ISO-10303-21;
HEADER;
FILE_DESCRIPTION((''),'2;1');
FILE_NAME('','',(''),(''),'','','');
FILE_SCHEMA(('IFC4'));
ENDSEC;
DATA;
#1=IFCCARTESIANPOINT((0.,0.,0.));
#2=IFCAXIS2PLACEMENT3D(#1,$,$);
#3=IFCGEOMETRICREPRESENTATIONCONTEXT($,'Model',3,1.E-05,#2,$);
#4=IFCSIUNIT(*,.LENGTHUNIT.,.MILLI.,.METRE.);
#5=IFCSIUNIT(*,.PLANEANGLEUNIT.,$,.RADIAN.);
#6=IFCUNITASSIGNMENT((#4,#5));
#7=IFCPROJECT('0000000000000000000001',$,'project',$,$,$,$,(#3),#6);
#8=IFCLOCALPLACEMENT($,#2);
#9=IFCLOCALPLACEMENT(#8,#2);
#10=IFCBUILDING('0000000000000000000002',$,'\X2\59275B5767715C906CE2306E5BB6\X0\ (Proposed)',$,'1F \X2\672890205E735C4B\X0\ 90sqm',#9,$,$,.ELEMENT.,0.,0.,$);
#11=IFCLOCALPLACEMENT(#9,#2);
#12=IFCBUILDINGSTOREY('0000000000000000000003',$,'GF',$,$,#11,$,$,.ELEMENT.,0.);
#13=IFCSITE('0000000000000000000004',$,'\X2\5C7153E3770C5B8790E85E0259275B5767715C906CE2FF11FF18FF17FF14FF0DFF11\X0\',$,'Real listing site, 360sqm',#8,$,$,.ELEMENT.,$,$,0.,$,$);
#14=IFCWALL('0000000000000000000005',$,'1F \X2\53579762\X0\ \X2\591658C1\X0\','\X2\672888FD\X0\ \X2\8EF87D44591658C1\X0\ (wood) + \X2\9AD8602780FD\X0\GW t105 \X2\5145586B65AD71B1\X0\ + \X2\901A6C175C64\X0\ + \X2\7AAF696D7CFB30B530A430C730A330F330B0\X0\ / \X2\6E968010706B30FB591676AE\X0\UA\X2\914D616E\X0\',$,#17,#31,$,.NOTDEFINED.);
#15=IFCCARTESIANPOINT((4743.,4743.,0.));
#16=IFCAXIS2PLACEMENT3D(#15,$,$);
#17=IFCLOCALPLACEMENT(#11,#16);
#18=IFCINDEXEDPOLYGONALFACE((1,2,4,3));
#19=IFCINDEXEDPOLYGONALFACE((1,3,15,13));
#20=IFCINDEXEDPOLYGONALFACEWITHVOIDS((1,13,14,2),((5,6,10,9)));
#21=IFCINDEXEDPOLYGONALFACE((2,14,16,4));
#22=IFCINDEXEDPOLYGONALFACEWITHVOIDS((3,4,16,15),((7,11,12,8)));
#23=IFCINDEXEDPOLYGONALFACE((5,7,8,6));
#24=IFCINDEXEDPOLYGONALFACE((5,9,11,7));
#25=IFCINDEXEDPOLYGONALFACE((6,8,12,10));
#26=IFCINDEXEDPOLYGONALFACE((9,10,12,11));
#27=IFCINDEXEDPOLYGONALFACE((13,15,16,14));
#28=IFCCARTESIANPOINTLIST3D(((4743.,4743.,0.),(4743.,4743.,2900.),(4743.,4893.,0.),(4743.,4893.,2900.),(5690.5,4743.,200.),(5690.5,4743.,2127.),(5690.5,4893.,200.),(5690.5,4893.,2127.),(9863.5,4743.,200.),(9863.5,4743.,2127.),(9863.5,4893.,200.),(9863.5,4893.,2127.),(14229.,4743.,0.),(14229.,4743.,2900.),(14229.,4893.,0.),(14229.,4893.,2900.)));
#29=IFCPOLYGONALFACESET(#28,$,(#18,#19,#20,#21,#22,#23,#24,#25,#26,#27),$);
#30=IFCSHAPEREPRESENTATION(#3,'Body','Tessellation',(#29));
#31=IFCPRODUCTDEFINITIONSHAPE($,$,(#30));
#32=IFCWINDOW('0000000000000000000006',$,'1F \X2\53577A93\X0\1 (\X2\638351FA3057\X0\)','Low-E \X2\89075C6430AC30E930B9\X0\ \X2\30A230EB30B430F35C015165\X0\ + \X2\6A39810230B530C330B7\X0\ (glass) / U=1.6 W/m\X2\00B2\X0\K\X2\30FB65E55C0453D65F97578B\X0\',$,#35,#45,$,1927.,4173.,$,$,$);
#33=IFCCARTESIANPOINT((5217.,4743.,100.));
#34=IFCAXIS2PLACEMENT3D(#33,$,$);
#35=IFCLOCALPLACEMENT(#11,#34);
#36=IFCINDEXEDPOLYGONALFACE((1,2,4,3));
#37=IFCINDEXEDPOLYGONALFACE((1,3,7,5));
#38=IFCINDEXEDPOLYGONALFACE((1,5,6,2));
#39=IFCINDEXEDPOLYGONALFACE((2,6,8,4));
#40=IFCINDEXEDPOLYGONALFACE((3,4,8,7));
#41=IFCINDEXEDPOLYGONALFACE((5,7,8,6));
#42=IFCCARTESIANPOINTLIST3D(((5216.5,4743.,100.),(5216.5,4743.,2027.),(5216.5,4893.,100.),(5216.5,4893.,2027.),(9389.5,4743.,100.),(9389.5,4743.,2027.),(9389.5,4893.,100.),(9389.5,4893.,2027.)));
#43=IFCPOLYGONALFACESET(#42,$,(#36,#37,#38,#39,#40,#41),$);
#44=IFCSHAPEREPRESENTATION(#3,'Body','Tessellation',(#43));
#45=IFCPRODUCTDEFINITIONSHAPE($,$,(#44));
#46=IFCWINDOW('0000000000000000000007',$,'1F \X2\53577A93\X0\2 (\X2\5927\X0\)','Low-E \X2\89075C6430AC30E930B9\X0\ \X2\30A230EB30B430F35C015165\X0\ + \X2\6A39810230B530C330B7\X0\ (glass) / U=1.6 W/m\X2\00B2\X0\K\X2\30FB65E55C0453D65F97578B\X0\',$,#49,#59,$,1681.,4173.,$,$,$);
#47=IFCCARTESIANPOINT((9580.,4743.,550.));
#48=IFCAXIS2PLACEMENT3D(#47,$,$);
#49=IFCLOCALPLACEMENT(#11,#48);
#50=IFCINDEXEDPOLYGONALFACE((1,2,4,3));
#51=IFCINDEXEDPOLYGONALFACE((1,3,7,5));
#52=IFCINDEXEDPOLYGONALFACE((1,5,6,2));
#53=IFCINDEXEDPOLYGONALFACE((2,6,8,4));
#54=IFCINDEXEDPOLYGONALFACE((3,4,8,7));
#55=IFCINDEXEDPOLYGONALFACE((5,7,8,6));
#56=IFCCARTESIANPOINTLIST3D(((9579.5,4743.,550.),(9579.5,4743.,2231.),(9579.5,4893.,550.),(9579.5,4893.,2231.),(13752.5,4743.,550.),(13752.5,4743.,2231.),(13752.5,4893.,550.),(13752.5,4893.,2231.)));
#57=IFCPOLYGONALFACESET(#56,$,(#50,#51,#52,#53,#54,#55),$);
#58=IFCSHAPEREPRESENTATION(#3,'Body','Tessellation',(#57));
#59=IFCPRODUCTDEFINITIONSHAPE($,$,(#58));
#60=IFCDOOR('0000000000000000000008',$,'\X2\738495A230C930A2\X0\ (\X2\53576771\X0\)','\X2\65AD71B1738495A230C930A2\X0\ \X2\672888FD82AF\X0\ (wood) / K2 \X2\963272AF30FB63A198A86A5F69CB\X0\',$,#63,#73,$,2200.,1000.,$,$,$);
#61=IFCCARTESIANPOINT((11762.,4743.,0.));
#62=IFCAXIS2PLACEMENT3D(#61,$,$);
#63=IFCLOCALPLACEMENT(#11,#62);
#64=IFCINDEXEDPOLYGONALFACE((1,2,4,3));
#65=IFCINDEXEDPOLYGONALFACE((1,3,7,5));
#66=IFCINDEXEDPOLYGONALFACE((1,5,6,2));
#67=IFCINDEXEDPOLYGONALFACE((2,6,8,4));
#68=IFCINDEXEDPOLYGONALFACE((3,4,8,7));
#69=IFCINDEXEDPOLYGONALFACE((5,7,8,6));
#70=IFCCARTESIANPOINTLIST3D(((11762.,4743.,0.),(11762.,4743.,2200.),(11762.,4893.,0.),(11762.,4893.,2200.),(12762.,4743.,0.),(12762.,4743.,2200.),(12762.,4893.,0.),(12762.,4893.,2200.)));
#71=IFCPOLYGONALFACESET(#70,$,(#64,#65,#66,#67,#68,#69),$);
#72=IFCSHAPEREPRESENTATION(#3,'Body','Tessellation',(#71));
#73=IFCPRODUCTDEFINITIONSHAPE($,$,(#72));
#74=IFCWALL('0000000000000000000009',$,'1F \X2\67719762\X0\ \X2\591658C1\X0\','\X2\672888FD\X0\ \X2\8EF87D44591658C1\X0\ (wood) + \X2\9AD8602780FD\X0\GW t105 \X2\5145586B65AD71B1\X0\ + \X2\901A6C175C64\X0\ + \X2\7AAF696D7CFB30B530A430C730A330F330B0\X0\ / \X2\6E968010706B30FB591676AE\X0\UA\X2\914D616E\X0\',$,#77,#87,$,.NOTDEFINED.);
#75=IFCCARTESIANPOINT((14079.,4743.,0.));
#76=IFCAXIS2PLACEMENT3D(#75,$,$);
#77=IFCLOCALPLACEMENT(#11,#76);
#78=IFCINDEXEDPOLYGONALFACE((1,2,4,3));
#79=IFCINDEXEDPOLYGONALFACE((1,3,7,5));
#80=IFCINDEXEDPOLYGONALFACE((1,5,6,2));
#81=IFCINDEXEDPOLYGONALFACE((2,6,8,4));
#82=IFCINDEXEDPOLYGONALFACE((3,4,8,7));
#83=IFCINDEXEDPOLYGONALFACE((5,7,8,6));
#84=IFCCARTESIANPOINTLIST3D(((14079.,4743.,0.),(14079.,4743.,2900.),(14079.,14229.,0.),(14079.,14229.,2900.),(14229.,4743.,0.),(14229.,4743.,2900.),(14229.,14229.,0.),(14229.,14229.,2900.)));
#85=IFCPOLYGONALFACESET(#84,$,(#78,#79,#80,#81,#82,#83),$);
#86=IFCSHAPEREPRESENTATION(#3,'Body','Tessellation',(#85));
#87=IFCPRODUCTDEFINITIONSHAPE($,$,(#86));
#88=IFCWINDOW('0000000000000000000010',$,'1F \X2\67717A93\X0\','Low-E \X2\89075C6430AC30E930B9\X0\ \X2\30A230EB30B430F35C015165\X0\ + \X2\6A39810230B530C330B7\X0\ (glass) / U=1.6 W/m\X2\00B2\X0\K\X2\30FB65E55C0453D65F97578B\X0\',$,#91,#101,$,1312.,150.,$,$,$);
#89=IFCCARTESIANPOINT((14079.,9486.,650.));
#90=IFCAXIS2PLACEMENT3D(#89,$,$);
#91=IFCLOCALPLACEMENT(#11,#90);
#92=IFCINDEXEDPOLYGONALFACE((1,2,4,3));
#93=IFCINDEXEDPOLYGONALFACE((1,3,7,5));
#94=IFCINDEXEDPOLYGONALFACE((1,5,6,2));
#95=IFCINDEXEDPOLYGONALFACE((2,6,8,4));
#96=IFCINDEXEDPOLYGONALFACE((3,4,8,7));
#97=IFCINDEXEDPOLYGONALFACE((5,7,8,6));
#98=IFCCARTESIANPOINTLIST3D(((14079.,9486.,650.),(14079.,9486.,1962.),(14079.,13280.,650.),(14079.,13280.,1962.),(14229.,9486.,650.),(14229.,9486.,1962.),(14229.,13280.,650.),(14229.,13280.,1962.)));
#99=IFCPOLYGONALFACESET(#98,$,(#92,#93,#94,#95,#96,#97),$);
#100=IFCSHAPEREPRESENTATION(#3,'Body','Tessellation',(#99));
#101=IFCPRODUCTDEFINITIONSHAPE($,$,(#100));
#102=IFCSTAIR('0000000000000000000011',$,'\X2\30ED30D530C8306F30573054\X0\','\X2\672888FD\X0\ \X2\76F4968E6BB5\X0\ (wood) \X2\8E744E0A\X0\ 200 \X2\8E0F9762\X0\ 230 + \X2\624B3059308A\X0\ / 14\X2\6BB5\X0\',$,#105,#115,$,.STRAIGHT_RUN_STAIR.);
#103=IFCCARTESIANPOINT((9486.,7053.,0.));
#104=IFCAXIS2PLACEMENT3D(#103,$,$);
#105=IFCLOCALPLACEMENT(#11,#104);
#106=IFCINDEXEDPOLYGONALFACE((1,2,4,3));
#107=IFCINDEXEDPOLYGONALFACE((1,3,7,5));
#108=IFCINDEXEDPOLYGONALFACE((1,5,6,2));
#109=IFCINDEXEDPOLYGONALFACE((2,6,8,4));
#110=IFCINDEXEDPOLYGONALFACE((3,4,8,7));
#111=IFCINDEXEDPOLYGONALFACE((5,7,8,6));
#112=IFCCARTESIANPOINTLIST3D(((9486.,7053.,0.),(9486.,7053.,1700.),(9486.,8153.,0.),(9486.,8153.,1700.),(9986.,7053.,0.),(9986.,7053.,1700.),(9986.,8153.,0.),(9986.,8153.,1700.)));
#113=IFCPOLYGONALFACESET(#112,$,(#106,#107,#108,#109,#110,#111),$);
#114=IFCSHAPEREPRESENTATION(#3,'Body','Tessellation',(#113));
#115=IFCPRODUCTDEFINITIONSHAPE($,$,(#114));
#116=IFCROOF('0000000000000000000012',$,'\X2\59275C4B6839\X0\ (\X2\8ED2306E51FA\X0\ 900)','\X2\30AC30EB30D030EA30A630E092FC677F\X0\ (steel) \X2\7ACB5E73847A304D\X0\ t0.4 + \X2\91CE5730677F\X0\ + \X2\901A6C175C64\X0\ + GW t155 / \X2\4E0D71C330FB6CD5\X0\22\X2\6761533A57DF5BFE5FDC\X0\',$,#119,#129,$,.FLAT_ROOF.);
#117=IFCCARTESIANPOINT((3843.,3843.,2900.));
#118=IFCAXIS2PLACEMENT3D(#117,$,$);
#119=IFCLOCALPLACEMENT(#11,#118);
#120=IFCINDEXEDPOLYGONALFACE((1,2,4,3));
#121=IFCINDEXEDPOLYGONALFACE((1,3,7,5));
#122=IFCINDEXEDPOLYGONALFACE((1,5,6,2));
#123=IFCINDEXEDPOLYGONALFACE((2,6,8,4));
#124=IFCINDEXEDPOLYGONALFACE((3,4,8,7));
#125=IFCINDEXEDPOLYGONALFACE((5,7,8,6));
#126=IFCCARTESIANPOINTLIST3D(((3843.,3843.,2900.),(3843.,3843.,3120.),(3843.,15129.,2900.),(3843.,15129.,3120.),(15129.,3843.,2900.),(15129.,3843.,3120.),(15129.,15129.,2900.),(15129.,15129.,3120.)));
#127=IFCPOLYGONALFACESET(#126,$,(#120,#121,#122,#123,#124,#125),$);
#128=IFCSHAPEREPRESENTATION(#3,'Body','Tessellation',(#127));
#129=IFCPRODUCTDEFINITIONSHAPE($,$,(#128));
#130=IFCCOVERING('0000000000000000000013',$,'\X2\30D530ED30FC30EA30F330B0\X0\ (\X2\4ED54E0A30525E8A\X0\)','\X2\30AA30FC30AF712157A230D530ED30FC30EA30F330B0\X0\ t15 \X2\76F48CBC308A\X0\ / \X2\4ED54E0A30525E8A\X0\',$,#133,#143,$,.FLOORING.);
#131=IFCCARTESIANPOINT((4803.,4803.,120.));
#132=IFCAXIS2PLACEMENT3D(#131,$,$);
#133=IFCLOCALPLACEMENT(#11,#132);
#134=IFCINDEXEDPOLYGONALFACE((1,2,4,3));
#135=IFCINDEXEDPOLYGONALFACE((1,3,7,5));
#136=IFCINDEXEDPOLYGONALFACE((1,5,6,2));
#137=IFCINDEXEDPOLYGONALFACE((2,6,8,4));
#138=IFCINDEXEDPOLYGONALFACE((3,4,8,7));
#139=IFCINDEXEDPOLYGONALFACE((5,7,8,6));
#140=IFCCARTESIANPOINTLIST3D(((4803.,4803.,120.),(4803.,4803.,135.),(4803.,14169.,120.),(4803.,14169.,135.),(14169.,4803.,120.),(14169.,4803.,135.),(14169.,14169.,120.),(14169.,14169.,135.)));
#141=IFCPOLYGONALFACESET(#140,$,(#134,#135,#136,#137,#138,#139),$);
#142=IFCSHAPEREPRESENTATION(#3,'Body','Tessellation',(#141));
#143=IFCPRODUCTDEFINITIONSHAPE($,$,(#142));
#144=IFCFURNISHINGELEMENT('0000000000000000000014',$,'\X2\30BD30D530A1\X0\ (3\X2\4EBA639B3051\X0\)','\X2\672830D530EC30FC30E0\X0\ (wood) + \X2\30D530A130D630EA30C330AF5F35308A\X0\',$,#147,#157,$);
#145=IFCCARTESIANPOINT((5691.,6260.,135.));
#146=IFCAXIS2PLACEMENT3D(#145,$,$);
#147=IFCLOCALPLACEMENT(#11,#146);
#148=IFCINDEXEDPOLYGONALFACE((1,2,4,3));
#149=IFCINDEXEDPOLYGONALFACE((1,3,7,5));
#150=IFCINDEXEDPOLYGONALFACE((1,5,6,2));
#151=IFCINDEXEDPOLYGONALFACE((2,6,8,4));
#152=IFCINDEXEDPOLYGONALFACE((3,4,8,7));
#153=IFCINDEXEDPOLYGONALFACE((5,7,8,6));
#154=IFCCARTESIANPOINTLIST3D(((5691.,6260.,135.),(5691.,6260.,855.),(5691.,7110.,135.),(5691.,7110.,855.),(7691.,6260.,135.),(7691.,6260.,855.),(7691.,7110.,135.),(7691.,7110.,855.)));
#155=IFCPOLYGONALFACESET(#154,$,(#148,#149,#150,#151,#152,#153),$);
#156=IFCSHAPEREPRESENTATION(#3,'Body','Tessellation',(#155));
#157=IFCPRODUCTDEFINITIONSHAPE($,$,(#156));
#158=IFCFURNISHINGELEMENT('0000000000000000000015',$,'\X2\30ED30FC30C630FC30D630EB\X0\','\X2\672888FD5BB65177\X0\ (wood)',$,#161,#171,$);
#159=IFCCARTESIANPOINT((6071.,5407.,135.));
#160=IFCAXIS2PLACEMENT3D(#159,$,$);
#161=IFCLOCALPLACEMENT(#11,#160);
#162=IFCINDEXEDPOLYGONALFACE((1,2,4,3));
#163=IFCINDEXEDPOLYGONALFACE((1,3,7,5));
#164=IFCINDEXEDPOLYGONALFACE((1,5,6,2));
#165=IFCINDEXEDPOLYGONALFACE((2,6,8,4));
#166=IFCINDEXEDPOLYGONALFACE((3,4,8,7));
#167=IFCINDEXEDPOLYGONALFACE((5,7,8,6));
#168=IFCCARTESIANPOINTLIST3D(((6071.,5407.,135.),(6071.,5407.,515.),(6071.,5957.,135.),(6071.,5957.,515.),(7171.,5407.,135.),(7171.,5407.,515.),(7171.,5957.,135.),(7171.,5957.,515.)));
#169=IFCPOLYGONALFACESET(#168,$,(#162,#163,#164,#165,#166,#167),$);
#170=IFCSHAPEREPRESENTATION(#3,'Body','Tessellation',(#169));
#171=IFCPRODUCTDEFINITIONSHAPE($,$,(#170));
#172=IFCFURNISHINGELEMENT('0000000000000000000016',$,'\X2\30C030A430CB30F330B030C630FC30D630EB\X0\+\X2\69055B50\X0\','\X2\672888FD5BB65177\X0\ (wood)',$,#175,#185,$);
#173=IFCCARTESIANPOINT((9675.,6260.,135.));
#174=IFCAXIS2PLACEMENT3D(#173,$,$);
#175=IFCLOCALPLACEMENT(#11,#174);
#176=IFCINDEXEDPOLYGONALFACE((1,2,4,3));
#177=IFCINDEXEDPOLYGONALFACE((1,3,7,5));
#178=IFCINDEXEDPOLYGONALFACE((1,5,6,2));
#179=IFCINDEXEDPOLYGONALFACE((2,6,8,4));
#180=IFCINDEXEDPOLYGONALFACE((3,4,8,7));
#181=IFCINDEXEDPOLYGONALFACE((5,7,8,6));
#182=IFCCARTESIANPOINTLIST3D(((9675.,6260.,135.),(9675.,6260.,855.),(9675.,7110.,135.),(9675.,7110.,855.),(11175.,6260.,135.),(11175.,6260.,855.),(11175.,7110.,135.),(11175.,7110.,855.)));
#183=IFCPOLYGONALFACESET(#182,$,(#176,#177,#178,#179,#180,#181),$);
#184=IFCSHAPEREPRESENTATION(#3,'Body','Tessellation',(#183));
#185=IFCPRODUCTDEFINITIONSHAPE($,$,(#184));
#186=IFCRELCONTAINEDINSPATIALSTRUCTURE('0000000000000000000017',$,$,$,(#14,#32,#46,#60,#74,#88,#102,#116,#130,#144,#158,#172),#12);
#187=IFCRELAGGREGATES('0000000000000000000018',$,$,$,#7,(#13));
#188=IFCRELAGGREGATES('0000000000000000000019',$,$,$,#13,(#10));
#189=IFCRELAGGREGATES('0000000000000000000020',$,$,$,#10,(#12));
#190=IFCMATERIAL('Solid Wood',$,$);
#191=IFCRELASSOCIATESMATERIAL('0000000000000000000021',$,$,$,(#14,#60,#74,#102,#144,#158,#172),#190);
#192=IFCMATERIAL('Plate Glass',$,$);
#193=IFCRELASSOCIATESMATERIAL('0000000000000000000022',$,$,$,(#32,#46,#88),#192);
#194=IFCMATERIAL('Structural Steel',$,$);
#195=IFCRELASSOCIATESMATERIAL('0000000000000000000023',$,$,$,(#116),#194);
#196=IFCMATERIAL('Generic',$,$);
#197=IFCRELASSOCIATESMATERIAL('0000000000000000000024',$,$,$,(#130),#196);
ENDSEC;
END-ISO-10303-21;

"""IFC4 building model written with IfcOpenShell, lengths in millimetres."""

from ifc_helpers import new_model, si_unit, frame, frame_2d, origin, place, context, project, spatial, rectangle, extrude, material, element, fill, save


model = new_model("IFC4")

# Units and contexts
model_context = context("Model", 3, precision=1e-05, world=origin())
ifc_project = project(units=[si_unit("LENGTHUNIT", "METRE", prefix="MILLI"), si_unit("PLANEANGLEUNIT", "RADIAN")], contexts=[model_context])

# Site, building, storey
site_placement = place(None, origin())
site = spatial("IfcSite", under=ifc_project, at=site_placement, Name="山口県宇部市大字東岐波１８７４－１", ObjectType="Real listing site, 360sqm", CompositionType="ELEMENT", RefElevation=0.0)
building_placement = place(site_placement, origin())
building = spatial("IfcBuilding", under=site, at=building_placement, Name="大字東岐波の家 (Proposed)", ObjectType="1F 木造平屋 90sqm", CompositionType="ELEMENT", ElevationOfRefHeight=0.0, ElevationOfTerrain=0.0)
storey_placement = place(building_placement, origin())
storey = spatial("IfcBuildingStorey", under=building, at=storey_placement, Name="GF", CompositionType="ELEMENT", Elevation=0.0)

# Shared definitions
ifc_material_1 = material(Name="Solid Wood")

# Wall, openings, windows, door
wall_1_placement = place(storey_placement, frame((4743.0, 4743.0, 0.0)))
wall_1 = element("IfcWall", 1, at=wall_1_placement, inside=storey, material=ifc_material_1, Name="1F 南面 外壁", Description="木製 軸組外壁 (wood) + 高性能GW t105 充填断熱 + 通気層 + 窯業系サイディング / 準耐火・外皮UA配慮", PredefinedType="NOTDEFINED", context=model_context, shape_type="SweptSolid", body=[
    extrude(rectangle(XDim=9486.0, YDim=150.0, at=frame_2d((4743.0, 75.0))), frame((4743.0, 4743.0, 0.0)), (0.0, 0.0, 1.0), 2900.0),
])
opening_1_placement = place(storey_placement, frame((5217.0, 4743.0, 100.0)))
opening_1 = element("IfcOpeningElement", 2, at=opening_1_placement, cuts=wall_1, PredefinedType="NOTDEFINED", context=model_context, shape_type="SweptSolid", body=[
    extrude(rectangle(XDim=4173.0, YDim=150.0, at=frame_2d((2086.0, 75.0))), frame((5217.0, 4743.0, 100.0)), (0.0, 0.0, 1.0), 1927.0),
])
opening_2_placement = place(storey_placement, frame((9580.0, 4743.0, 550.0)))
opening_2 = element("IfcOpeningElement", 3, at=opening_2_placement, cuts=wall_1, PredefinedType="NOTDEFINED", context=model_context, shape_type="SweptSolid", body=[
    extrude(rectangle(XDim=4173.0, YDim=150.0, at=frame_2d((2086.0, 75.0))), frame((9580.0, 4743.0, 550.0)), (0.0, 0.0, 1.0), 1681.0),
])
opening_3_placement = place(storey_placement, frame((11762.0, 4743.0, 0.0)))
opening_3 = element("IfcOpeningElement", 4, at=opening_3_placement, cuts=wall_1, PredefinedType="NOTDEFINED", context=model_context, shape_type="SweptSolid", body=[
    extrude(rectangle(XDim=1000.0, YDim=150.0, at=frame_2d((500.0, 75.0))), frame((11762.0, 4743.0, 0.0)), (0.0, 0.0, 1.0), 2200.0),
])
ifc_material_2 = material(Name="Plate Glass")
window_1_placement = place(storey_placement, frame((5217.0, 4743.0, 100.0)))
window_1 = element("IfcWindow", 5, at=window_1_placement, inside=storey, material=ifc_material_2, Name="1F 南窓1 (掃出し)", Description="Low-E 複層ガラス アルゴン封入 + 樹脂サッシ (glass) / U=1.6 W/m²K・日射取得型", OverallHeight=1927.0, OverallWidth=4173.0, context=model_context, shape_type="SweptSolid", body=[
    extrude(rectangle(XDim=4173.0, YDim=150.0, at=frame_2d((2086.0, 75.0))), frame((5217.0, 4743.0, 100.0)), (0.0, 0.0, 1.0), 1927.0),
])
fill(opening_1, window_1)
window_2_placement = place(storey_placement, frame((9580.0, 4743.0, 550.0)))
window_2 = element("IfcWindow", 6, at=window_2_placement, inside=storey, material=ifc_material_2, Name="1F 南窓2 (大)", Description="Low-E 複層ガラス アルゴン封入 + 樹脂サッシ (glass) / U=1.6 W/m²K・日射取得型", OverallHeight=1681.0, OverallWidth=4173.0, context=model_context, shape_type="SweptSolid", body=[
    extrude(rectangle(XDim=4173.0, YDim=150.0, at=frame_2d((2086.0, 75.0))), frame((9580.0, 4743.0, 550.0)), (0.0, 0.0, 1.0), 1681.0),
])
fill(opening_2, window_2)
door_placement = place(storey_placement, frame((11762.0, 4743.0, 0.0)))
door = element("IfcDoor", 7, at=door_placement, inside=storey, material=ifc_material_1, Name="玄関ドア (南東)", Description="断熱玄関ドア 木製芯 (wood) / K2 防犯・採風機構", OverallHeight=2200.0, OverallWidth=1000.0, context=model_context, shape_type="SweptSolid", body=[
    extrude(rectangle(XDim=1000.0, YDim=150.0, at=frame_2d((500.0, 75.0))), frame((11762.0, 4743.0, 0.0)), (0.0, 0.0, 1.0), 2200.0),
])
fill(opening_3, door)

# Wall, opening, window
wall_2_placement = place(storey_placement, frame((14079.0, 4743.0, 0.0)))
wall_2 = element("IfcWall", 8, at=wall_2_placement, inside=storey, material=ifc_material_1, Name="1F 東面 外壁", Description="木製 軸組外壁 (wood) + 高性能GW t105 充填断熱 + 通気層 + 窯業系サイディング / 準耐火・外皮UA配慮", PredefinedType="NOTDEFINED", context=model_context, shape_type="SweptSolid", body=[
    extrude(rectangle(XDim=150.0, YDim=9486.0, at=frame_2d((75.0, 4743.0))), frame((14079.0, 4743.0, 0.0)), (0.0, 0.0, 1.0), 2900.0),
])
opening_4_placement = place(storey_placement, frame((14079.0, 9486.0, 650.0)))
opening_4 = element("IfcOpeningElement", 9, at=opening_4_placement, cuts=wall_2, PredefinedType="NOTDEFINED", context=model_context, shape_type="SweptSolid", body=[
    extrude(rectangle(XDim=150.0, YDim=3794.0, at=frame_2d((75.0, 1897.0))), frame((14079.0, 9486.0, 650.0)), (0.0, 0.0, 1.0), 1312.0),
])
window_3_placement = place(storey_placement, frame((14079.0, 9486.0, 650.0)))
window_3 = element("IfcWindow", 10, at=window_3_placement, inside=storey, material=ifc_material_2, Name="1F 東窓", Description="Low-E 複層ガラス アルゴン封入 + 樹脂サッシ (glass) / U=1.6 W/m²K・日射取得型", OverallHeight=1312.0, OverallWidth=150.0, context=model_context, shape_type="SweptSolid", body=[
    extrude(rectangle(XDim=150.0, YDim=3794.0, at=frame_2d((75.0, 1897.0))), frame((14079.0, 9486.0, 650.0)), (0.0, 0.0, 1.0), 1312.0),
])
fill(opening_4, window_3)

# Stair
stair_placement = place(storey_placement, frame((9486.0, 7053.0, 0.0)))
element("IfcStair", 11, at=stair_placement, inside=storey, material=ifc_material_1, Name="ロフトはしご", Description="木製 直階段 (wood) 蹴上 200 踏面 230 + 手すり / 14段", PredefinedType="STRAIGHT_RUN_STAIR", context=model_context, shape_type="SweptSolid", body=[
    extrude(rectangle(XDim=500.0, YDim=1100.0, at=frame_2d((250.0, 550.0))), frame((9486.0, 7053.0, 0.0)), (0.0, 0.0, 1.0), 1700.0),
])

# Roof
ifc_material_3 = material(Name="Structural Steel")
roof_placement = place(storey_placement, frame((3843.0, 3843.0, 2900.0)))
element("IfcRoof", 12, at=roof_placement, inside=storey, material=ifc_material_3, Name="大屋根 (軒の出 900)", Description="ガルバリウム鋼板 (steel) 立平葺き t0.4 + 野地板 + 通気層 + GW t155 / 不燃・法22条区域対応", PredefinedType="FLAT_ROOF", context=model_context, shape_type="SweptSolid", body=[
    extrude(rectangle(XDim=11286.0, YDim=11286.0, at=frame_2d((5643.0, 5643.0))), frame((3843.0, 3843.0, 2900.0)), (0.0, 0.0, 1.0), 220.0),
])

# Covering
ifc_material_4 = material(Name="Generic")
covering_placement = place(storey_placement, frame((4803.0, 4803.0, 120.0)))
element("IfcCovering", 13, at=covering_placement, inside=storey, material=ifc_material_4, Name="フローリング (仕上げ床)", Description="オーク無垢フローリング t15 直貼り / 仕上げ床", PredefinedType="FLOORING", context=model_context, shape_type="SweptSolid", body=[
    extrude(rectangle(XDim=9366.0, YDim=9366.0, at=frame_2d((4683.0, 4683.0))), frame((4803.0, 4803.0, 120.0)), (0.0, 0.0, 1.0), 15.0),
])

# Furnishing elements
furnishing_1_placement = place(storey_placement, frame((5691.0, 6260.0, 135.0)))
element("IfcFurnishingElement", 14, at=furnishing_1_placement, inside=storey, material=ifc_material_1, Name="ソファ (3人掛け)", Description="木フレーム (wood) + ファブリック張り", context=model_context, shape_type="SweptSolid", body=[
    extrude(rectangle(XDim=2000.0, YDim=850.0, at=frame_2d((1000.0, 425.0))), frame((5691.0, 6260.0, 135.0)), (0.0, 0.0, 1.0), 720.0),
])
furnishing_2_placement = place(storey_placement, frame((6071.0, 5407.0, 135.0)))
element("IfcFurnishingElement", 15, at=furnishing_2_placement, inside=storey, material=ifc_material_1, Name="ローテーブル", Description="木製家具 (wood)", context=model_context, shape_type="SweptSolid", body=[
    extrude(rectangle(XDim=1100.0, YDim=550.0, at=frame_2d((550.0, 275.0))), frame((6071.0, 5407.0, 135.0)), (0.0, 0.0, 1.0), 380.0),
])
furnishing_3_placement = place(storey_placement, frame((9675.0, 6260.0, 135.0)))
element("IfcFurnishingElement", 16, at=furnishing_3_placement, inside=storey, material=ifc_material_1, Name="ダイニングテーブル+椅子", Description="木製家具 (wood)", context=model_context, shape_type="SweptSolid", body=[
    extrude(rectangle(XDim=1500.0, YDim=850.0, at=frame_2d((750.0, 425.0))), frame((9675.0, 6260.0, 135.0)), (0.0, 0.0, 1.0), 720.0),
])

save(model, "model.ifc")
